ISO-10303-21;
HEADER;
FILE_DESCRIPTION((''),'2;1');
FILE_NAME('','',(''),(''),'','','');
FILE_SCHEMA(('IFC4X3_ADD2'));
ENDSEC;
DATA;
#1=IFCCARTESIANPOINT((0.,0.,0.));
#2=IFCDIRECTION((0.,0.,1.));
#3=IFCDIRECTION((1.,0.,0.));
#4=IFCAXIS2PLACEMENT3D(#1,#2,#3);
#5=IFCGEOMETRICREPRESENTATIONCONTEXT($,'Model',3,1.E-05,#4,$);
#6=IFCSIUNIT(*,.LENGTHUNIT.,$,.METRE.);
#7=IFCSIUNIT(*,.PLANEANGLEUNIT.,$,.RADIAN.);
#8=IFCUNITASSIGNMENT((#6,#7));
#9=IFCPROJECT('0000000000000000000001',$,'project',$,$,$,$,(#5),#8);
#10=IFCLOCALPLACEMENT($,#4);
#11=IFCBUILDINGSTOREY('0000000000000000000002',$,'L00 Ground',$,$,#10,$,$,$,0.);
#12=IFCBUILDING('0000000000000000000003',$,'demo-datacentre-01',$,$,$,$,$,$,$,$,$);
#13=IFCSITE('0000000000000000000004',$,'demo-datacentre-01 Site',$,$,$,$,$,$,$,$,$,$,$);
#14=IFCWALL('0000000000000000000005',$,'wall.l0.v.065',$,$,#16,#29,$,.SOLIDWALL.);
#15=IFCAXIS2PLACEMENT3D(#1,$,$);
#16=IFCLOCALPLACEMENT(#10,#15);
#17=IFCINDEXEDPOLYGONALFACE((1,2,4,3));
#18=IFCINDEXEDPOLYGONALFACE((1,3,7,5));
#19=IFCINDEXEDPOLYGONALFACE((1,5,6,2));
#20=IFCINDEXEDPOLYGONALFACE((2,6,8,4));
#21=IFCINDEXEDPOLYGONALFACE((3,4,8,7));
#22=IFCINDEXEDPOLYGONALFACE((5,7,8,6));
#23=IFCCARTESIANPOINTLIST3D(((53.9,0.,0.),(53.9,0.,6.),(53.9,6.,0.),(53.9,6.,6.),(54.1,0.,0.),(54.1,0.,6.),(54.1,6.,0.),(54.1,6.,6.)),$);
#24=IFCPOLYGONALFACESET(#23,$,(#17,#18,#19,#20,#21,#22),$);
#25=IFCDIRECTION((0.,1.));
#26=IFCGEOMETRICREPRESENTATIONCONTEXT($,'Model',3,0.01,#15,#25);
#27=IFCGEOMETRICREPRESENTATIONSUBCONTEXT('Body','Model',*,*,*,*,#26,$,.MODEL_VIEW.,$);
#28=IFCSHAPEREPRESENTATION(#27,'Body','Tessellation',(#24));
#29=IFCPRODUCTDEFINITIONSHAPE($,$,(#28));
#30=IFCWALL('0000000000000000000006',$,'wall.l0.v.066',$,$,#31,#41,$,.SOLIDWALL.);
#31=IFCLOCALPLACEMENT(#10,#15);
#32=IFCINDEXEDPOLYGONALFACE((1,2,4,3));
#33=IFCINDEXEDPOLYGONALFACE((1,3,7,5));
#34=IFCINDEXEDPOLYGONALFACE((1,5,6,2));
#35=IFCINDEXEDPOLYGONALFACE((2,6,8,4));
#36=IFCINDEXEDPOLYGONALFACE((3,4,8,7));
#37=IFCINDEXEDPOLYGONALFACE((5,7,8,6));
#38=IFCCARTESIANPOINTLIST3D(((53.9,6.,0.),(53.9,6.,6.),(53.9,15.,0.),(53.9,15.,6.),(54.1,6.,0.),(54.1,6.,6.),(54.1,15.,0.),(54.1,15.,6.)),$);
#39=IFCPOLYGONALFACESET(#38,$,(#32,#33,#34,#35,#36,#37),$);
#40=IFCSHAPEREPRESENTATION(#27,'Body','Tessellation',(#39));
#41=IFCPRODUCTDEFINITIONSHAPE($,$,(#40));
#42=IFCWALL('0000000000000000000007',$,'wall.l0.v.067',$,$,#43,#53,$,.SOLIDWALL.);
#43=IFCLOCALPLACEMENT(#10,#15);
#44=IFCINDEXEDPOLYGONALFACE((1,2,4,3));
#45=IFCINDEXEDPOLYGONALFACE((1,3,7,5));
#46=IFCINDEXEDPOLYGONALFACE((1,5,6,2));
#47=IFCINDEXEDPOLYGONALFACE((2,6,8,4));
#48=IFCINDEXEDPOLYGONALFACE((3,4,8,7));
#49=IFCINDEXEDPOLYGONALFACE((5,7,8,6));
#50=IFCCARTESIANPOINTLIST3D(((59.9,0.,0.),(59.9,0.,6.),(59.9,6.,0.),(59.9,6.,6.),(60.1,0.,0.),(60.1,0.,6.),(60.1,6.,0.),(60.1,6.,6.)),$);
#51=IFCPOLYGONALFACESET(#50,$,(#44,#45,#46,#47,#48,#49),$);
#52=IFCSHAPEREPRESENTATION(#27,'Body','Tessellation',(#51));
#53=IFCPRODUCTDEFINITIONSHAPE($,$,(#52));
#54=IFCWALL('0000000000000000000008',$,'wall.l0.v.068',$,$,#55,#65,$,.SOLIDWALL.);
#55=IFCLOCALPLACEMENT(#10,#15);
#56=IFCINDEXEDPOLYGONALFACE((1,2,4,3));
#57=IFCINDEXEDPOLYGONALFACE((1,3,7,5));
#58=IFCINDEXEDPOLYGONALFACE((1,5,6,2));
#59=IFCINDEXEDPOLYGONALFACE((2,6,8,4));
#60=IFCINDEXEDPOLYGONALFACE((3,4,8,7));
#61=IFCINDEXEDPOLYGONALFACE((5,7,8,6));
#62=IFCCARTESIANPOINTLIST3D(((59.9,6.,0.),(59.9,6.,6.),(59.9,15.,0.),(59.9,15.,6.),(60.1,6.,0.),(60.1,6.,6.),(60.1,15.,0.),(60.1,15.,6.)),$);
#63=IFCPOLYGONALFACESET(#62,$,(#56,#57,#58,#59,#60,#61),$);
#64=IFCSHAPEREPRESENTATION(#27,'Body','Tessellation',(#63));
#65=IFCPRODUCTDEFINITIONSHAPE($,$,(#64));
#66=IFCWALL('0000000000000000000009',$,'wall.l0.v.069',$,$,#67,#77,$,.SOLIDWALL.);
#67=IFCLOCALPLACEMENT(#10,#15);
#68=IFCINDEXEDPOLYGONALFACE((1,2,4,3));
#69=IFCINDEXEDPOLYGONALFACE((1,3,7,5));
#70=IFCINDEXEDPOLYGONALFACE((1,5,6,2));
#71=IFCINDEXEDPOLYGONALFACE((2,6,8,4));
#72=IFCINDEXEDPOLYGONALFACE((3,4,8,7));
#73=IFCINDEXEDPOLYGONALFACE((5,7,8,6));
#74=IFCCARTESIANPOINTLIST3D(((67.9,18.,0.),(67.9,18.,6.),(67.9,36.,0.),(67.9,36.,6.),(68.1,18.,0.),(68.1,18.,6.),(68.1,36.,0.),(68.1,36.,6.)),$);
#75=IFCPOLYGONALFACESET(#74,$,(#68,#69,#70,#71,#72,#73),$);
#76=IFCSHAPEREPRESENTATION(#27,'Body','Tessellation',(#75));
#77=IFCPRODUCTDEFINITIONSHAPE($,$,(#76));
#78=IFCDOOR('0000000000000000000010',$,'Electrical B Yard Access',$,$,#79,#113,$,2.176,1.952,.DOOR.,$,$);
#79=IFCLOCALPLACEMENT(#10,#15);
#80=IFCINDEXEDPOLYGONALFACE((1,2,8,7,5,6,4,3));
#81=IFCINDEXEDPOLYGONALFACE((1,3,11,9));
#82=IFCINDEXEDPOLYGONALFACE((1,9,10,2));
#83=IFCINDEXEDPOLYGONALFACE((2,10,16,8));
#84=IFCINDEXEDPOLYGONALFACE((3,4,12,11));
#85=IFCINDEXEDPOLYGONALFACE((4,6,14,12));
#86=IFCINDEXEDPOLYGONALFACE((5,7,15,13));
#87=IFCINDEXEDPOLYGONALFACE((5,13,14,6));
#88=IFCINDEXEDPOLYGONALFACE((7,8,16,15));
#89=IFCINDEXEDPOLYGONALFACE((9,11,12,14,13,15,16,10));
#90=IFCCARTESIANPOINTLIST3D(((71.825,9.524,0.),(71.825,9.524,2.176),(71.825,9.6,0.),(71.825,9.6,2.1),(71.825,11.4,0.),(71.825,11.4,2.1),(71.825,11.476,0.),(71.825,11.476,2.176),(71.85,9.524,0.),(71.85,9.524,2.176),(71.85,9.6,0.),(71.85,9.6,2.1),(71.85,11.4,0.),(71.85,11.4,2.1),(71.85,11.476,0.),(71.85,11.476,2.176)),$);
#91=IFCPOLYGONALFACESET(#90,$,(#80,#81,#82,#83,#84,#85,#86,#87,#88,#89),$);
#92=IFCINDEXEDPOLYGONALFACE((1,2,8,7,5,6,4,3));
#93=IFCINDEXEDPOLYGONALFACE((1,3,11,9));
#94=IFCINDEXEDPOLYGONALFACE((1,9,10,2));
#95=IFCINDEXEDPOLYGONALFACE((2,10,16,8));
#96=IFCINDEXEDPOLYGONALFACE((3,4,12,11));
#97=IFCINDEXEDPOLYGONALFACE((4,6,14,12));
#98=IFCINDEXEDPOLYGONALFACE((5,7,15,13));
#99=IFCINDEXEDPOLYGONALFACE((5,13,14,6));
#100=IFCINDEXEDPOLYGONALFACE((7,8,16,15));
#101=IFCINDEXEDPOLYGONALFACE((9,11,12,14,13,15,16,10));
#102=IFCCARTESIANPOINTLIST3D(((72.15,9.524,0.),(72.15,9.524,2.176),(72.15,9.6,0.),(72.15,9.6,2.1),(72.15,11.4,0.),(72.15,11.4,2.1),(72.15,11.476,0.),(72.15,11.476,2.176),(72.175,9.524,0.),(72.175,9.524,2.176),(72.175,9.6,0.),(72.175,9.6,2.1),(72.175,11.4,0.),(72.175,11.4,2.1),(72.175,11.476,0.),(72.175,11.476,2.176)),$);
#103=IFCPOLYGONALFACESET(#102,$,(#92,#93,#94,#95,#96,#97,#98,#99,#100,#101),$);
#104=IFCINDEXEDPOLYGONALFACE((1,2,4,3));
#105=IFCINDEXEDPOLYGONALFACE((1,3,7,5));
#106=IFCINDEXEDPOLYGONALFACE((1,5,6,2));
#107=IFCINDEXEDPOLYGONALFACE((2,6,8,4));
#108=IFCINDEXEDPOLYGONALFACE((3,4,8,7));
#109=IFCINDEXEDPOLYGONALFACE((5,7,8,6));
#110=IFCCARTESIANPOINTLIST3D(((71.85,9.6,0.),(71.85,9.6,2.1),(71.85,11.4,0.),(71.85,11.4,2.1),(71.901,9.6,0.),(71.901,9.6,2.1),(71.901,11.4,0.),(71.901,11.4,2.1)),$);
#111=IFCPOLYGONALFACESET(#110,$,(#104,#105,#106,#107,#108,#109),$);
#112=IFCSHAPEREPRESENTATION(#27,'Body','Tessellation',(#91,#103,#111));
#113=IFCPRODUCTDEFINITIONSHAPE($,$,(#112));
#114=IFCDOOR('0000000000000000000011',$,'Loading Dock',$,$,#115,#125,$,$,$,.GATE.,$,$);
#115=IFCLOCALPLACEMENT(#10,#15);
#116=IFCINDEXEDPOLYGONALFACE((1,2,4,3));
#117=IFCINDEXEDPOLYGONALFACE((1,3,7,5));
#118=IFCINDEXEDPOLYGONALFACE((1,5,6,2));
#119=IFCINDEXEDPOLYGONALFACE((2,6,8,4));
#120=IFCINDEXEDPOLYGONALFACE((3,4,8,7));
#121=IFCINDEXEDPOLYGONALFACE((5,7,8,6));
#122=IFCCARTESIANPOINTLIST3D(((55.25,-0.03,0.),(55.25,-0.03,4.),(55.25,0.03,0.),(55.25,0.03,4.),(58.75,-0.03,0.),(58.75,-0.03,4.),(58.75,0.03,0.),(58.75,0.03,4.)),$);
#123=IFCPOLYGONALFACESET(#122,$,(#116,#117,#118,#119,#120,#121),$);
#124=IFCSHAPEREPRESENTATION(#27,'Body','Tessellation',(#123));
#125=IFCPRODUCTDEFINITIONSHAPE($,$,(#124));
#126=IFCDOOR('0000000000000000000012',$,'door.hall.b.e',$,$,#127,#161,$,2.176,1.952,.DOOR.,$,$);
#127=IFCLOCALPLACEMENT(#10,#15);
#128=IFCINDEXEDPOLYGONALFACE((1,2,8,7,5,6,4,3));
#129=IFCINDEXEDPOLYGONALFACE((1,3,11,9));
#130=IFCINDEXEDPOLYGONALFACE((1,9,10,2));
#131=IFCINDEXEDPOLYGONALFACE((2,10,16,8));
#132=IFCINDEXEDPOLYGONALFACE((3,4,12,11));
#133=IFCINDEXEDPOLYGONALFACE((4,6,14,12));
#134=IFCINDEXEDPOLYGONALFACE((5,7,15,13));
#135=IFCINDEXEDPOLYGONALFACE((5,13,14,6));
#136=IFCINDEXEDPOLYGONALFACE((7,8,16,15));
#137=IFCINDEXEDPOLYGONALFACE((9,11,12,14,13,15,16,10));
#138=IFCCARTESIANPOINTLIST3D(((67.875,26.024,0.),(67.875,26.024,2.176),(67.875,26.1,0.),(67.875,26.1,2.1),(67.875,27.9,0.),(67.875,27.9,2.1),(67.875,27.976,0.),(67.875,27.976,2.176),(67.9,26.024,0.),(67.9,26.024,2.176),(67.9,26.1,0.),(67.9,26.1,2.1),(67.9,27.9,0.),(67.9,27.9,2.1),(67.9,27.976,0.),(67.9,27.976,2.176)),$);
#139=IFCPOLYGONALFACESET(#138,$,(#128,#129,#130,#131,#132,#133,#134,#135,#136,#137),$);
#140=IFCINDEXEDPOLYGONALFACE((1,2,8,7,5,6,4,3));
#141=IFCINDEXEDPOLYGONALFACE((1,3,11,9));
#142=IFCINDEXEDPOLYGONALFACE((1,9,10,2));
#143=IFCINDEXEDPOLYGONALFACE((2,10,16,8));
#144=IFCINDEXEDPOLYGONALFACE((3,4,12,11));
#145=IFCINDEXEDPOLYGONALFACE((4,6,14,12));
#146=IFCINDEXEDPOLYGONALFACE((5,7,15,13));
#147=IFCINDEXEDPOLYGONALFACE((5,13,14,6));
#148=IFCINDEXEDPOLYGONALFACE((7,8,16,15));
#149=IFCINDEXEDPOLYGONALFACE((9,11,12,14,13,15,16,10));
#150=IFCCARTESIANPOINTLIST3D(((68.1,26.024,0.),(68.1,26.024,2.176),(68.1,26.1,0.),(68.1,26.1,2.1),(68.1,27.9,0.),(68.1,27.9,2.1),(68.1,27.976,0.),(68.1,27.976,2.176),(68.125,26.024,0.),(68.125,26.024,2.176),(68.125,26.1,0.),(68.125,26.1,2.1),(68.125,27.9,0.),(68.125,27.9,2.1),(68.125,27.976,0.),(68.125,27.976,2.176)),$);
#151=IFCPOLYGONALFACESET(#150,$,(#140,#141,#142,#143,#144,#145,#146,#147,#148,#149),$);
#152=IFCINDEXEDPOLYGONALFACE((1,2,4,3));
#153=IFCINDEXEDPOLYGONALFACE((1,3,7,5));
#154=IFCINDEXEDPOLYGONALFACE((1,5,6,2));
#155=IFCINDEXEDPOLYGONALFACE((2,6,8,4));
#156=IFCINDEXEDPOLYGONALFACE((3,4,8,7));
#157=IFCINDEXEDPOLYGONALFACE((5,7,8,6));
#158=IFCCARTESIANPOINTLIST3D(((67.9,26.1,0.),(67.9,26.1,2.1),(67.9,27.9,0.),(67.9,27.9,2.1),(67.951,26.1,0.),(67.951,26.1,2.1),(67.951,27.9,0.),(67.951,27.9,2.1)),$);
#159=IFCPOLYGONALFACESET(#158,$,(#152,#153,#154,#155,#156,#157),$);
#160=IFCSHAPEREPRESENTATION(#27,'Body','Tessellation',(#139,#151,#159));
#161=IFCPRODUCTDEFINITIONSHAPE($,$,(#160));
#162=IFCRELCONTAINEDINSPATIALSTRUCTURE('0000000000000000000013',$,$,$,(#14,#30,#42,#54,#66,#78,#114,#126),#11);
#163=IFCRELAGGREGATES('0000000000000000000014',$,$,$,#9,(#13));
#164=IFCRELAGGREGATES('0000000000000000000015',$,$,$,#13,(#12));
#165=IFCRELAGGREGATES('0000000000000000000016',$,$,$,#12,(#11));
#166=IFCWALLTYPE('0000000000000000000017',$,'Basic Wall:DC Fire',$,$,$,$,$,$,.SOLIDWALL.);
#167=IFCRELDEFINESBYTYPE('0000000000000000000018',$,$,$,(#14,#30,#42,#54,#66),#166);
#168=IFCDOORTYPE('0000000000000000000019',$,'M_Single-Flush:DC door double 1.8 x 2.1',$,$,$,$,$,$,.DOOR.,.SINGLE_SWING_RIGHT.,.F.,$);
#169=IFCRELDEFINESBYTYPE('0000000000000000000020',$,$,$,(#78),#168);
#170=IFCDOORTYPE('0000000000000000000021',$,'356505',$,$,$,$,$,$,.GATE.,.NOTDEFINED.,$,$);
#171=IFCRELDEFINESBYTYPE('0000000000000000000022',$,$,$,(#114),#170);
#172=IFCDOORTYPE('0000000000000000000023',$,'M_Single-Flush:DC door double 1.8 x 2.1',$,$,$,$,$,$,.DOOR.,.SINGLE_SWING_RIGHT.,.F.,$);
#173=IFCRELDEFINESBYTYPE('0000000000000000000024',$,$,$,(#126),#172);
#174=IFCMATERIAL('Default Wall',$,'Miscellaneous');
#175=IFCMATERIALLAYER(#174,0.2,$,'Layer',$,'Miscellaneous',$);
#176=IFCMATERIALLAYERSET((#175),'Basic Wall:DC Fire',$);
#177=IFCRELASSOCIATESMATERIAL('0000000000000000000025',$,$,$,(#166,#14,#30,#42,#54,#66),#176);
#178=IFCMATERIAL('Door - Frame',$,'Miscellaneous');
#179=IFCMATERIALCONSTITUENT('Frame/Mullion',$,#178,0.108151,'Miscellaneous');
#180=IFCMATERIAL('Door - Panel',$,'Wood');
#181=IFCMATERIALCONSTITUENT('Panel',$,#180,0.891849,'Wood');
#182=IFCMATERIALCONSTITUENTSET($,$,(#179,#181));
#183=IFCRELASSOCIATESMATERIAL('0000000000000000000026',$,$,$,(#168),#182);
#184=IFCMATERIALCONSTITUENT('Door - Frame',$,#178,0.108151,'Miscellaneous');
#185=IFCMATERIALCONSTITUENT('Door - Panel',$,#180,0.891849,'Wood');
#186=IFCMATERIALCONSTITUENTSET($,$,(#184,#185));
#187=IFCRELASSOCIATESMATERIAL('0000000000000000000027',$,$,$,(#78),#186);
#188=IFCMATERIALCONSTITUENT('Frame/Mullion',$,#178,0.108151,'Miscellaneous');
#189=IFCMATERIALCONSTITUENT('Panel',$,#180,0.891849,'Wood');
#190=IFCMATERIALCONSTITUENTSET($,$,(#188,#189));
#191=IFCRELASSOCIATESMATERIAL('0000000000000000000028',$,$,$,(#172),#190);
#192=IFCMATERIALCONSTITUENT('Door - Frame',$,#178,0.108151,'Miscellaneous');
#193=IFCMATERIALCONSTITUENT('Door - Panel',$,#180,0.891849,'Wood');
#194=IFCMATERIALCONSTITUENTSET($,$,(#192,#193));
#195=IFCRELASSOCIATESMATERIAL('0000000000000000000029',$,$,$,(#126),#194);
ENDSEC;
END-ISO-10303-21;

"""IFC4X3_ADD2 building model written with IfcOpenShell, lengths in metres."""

from ifc_helpers import new_model, si_unit, direction, frame, frame_2d, origin, origin_with_axes, origin_2d_with_axis, place, context, subcontext, project, spatial, polyline, rectangle, outline, extrude, source, transform, mapped, material, layer, layer_set, constituent, constituent_set, type_object, type_shapes, element, save


model = new_model("IFC4X3_ADD2")

# Units and contexts
model_context_1 = context("Model", 3, precision=0.01, world=origin(), true_north=direction((0.0, 1.0)))
model_context_2 = context("Model", 3, precision=1e-05, world=origin_with_axes())
body_context = subcontext(model_context_1, "Body", "Model", "MODEL_VIEW")
ifc_project = project(units=[si_unit("LENGTHUNIT", "METRE"), si_unit("PLANEANGLEUNIT", "RADIAN")], contexts=[model_context_2])

# Site, building, storey
site = spatial("IfcSite", under=ifc_project, Name="demo-datacentre-01 Site")
building = spatial("IfcBuilding", under=site, Name="demo-datacentre-01")
storey_placement = place(None, origin_with_axes())
storey = spatial("IfcBuildingStorey", under=building, at=storey_placement, Name="L00 Ground", Elevation=0.0)

# Shared definitions
ifc_material_1 = material(Name="Default Wall", Category="Miscellaneous")
placement_1 = place(None, origin())
placement_2 = place(placement_1, origin())
placement_3 = place(placement_2, origin())

# Walls
ifc_layer_1 = layer(ifc_material_1, 0.2, Name="Layer", Category="Miscellaneous")
ifc_layer_set_1 = layer_set([ifc_layer_1], Name="Basic Wall:DC Fire")
wall_type_1 = type_object("IfcWallType", Name="Basic Wall:DC Fire", PredefinedType="SOLIDWALL", material=ifc_layer_set_1)
wall_1_placement = place(placement_3, frame((54.0, 0.0, 0.0), z_axis=(0.0, 0.0, 1.0), x_axis=(0.0, 1.0, 0.0)))
element("IfcWall", 1, at=wall_1_placement, inside=storey, type_object=wall_type_1, material=ifc_layer_set_1, Name="wall.l0.v.065", PredefinedType="SOLIDWALL", context=body_context, shape_type="SweptSolid", body=[
    extrude(rectangle(XDim=6.0, YDim=0.2, at=frame_2d((3.0, 0.0), x_axis=(-1.0, 0.0))), origin(), (0.0, 0.0, 1.0), 6.0),
])
wall_2_placement = place(placement_3, frame((54.0, 6.0, 0.0), z_axis=(0.0, 0.0, 1.0), x_axis=(0.0, 1.0, 0.0)))
element("IfcWall", 2, at=wall_2_placement, inside=storey, type_object=wall_type_1, material=ifc_layer_set_1, Name="wall.l0.v.066", PredefinedType="SOLIDWALL", context=body_context, shape_type="SweptSolid", body=[
    extrude(rectangle(XDim=9.0, YDim=0.2, at=frame_2d((4.5, 0.0), x_axis=(-1.0, 0.0))), origin(), (0.0, 0.0, 1.0), 6.0),
])
wall_3_placement = place(placement_3, frame((60.0, 0.0, 0.0), z_axis=(0.0, 0.0, 1.0), x_axis=(0.0, 1.0, 0.0)))
element("IfcWall", 3, at=wall_3_placement, inside=storey, type_object=wall_type_1, material=ifc_layer_set_1, Name="wall.l0.v.067", PredefinedType="SOLIDWALL", context=body_context, shape_type="SweptSolid", body=[
    extrude(rectangle(XDim=6.0, YDim=0.2, at=frame_2d((3.0, 0.0), x_axis=(-1.0, 0.0))), origin(), (0.0, 0.0, 1.0), 6.0),
])
wall_4_placement = place(placement_3, frame((60.0, 6.0, 0.0), z_axis=(0.0, 0.0, 1.0), x_axis=(0.0, 1.0, 0.0)))
element("IfcWall", 4, at=wall_4_placement, inside=storey, type_object=wall_type_1, material=ifc_layer_set_1, Name="wall.l0.v.068", PredefinedType="SOLIDWALL", context=body_context, shape_type="SweptSolid", body=[
    extrude(rectangle(XDim=9.0, YDim=0.2, at=frame_2d((4.5, 0.0), x_axis=(-1.0, 0.0))), origin(), (0.0, 0.0, 1.0), 6.0),
])
wall_5_placement = place(placement_3, frame((68.0, 18.0, 0.0), z_axis=(0.0, 0.0, 1.0), x_axis=(0.0, 1.0, 0.0)))
element("IfcWall", 5, at=wall_5_placement, inside=storey, type_object=wall_type_1, material=ifc_layer_set_1, Name="wall.l0.v.069", PredefinedType="SOLIDWALL", context=body_context, shape_type="SweptSolid", body=[
    extrude(rectangle(XDim=18.0, YDim=0.2, at=frame_2d((9.0, 0.0), x_axis=(-1.0, 0.0))), origin(), (0.0, 0.0, 1.0), 6.0),
])

# Doors
ifc_material_2 = material(Name="Door - Frame", Category="Miscellaneous")
ifc_constituent_1 = constituent(ifc_material_2, Name="Door - Frame", Category="Miscellaneous", fraction=0.108151)
ifc_material_3 = material(Name="Door - Panel", Category="Wood")
ifc_constituent_2 = constituent(ifc_material_3, Name="Door - Panel", Category="Wood", fraction=0.891849)
ifc_constituent_set_1 = constituent_set(constituents=[ifc_constituent_1, ifc_constituent_2])
ifc_constituent_3 = constituent(ifc_material_2, Name="Frame/Mullion", Category="Miscellaneous", fraction=0.108151)
ifc_constituent_4 = constituent(ifc_material_3, Name="Panel", Category="Wood", fraction=0.891849)
ifc_constituent_set_2 = constituent_set(constituents=[ifc_constituent_3, ifc_constituent_4])
door_type_1 = type_object("IfcDoorType", Name="M_Single-Flush:DC door double 1.8 x 2.1", OperationType="SINGLE_SWING_RIGHT", ParameterTakesPrecedence=False, PredefinedType="DOOR", material=ifc_constituent_set_2)
shared_shape_1 = source(origin(), body_context, "Body", "SweptSolid", [
    extrude(outline(polyline([(-0.976, -1.107), (0.976, -1.107), (0.976, 1.069), (0.9, 1.069), (0.9, -1.031), (-0.9, -1.031), (-0.9, 1.069), (-0.976, 1.069), (-0.976, -1.107)])), frame((0.9, 0.3, 1.069), z_axis=(0.0, 1.0, 0.0), x_axis=(1.0, 0.0, 0.0)), (0.0, 0.0, 1.0), 0.025),
    extrude(outline(polyline([(-1.107, -0.976), (1.069, -0.976), (1.069, -0.9), (-1.031, -0.9), (-1.031, 0.9), (1.069, 0.9), (1.069, 0.976), (-1.107, 0.976), (-1.107, -0.976)])), frame((0.9, -0.025, 1.069), z_axis=(0.0, 1.0, 0.0), x_axis=(0.0, 0.0, -1.0)), (0.0, 0.0, 1.0), 0.025),
    extrude(rectangle(XDim=0.051, YDim=1.8, at=frame_2d((0.0, 0.0), x_axis=(1.0, 0.0))), frame((0.9, 0.2745, 0.0), z_axis=(0.0, 0.0, 1.0), x_axis=(0.0, 1.0, 0.0)), (0.0, 0.0, 1.0), 2.1),
])
type_shapes(door_type_1, [shared_shape_1])
door_1_placement = place(placement_3, frame((72.15, 9.6, 0.0), z_axis=(0.0, 0.0, 1.0), x_axis=(0.0, 1.0, 0.0)))
element("IfcDoor", 6, at=door_1_placement, inside=storey, type_object=door_type_1, material=ifc_constituent_set_1, Name="Electrical B Yard Access", OverallHeight=2.176, OverallWidth=1.952, PredefinedType="DOOR", context=body_context, shape_type="MappedRepresentation", body=[
    mapped(shared_shape_1, transform((0.0, 0.0, 0.0), scale=1.0)),
])
door_type_2 = type_object("IfcDoorType", Name="356505", OperationType="NOTDEFINED", PredefinedType="GATE")
door_2_placement = place(placement_3, frame((55.25, -0.03, 0.0)))
element("IfcDoor", 7, at=door_2_placement, inside=storey, type_object=door_type_2, Name="Loading Dock", PredefinedType="GATE", context=body_context, shape_type="SweptSolid", body=[
    extrude(rectangle(XDim=3.5, YDim=0.06, at=origin_2d_with_axis()), frame((1.75, 0.03, 0.0)), (0.0, 0.0, 1.0), 4.0),
])
ifc_constituent_5 = constituent(ifc_material_2, Name="Door - Frame", Category="Miscellaneous", fraction=0.108151)
ifc_constituent_6 = constituent(ifc_material_3, Name="Door - Panel", Category="Wood", fraction=0.891849)
ifc_constituent_set_3 = constituent_set(constituents=[ifc_constituent_5, ifc_constituent_6])
ifc_constituent_7 = constituent(ifc_material_2, Name="Frame/Mullion", Category="Miscellaneous", fraction=0.108151)
ifc_constituent_8 = constituent(ifc_material_3, Name="Panel", Category="Wood", fraction=0.891849)
ifc_constituent_set_4 = constituent_set(constituents=[ifc_constituent_7, ifc_constituent_8])
door_type_3 = type_object("IfcDoorType", Name="M_Single-Flush:DC door double 1.8 x 2.1", OperationType="SINGLE_SWING_RIGHT", ParameterTakesPrecedence=False, PredefinedType="DOOR", material=ifc_constituent_set_4)
shared_shape_2 = source(origin(), body_context, "Body", "SweptSolid", [
    extrude(outline(polyline([(-0.976, -1.107), (0.976, -1.107), (0.976, 1.069), (0.9, 1.069), (0.9, -1.031), (-0.9, -1.031), (-0.9, 1.069), (-0.976, 1.069), (-0.976, -1.107)])), frame((0.9, 0.2, 1.069), z_axis=(0.0, 1.0, 0.0), x_axis=(1.0, 0.0, 0.0)), (0.0, 0.0, 1.0), 0.025),
    extrude(outline(polyline([(-1.107, -0.976), (1.069, -0.976), (1.069, -0.9), (-1.031, -0.9), (-1.031, 0.9), (1.069, 0.9), (1.069, 0.976), (-1.107, 0.976), (-1.107, -0.976)])), frame((0.9, -0.025, 1.069), z_axis=(0.0, 1.0, 0.0), x_axis=(0.0, 0.0, -1.0)), (0.0, 0.0, 1.0), 0.025),
    extrude(rectangle(XDim=0.051, YDim=1.8, at=frame_2d((0.0, 0.0), x_axis=(1.0, 0.0))), frame((0.9, 0.1745, 0.0), z_axis=(0.0, 0.0, 1.0), x_axis=(0.0, 1.0, 0.0)), (0.0, 0.0, 1.0), 2.1),
])
type_shapes(door_type_3, [shared_shape_2])
door_3_placement = place(placement_3, frame((68.1, 26.1, 0.0), z_axis=(0.0, 0.0, 1.0), x_axis=(0.0, 1.0, 0.0)))
element("IfcDoor", 8, at=door_3_placement, inside=storey, type_object=door_type_3, material=ifc_constituent_set_3, Name="door.hall.b.e", OverallHeight=2.176, OverallWidth=1.952, PredefinedType="DOOR", context=body_context, shape_type="MappedRepresentation", body=[
    mapped(shared_shape_2, transform((0.0, 0.0, 0.0), scale=1.0)),
])

save(model, "model.ifc")
